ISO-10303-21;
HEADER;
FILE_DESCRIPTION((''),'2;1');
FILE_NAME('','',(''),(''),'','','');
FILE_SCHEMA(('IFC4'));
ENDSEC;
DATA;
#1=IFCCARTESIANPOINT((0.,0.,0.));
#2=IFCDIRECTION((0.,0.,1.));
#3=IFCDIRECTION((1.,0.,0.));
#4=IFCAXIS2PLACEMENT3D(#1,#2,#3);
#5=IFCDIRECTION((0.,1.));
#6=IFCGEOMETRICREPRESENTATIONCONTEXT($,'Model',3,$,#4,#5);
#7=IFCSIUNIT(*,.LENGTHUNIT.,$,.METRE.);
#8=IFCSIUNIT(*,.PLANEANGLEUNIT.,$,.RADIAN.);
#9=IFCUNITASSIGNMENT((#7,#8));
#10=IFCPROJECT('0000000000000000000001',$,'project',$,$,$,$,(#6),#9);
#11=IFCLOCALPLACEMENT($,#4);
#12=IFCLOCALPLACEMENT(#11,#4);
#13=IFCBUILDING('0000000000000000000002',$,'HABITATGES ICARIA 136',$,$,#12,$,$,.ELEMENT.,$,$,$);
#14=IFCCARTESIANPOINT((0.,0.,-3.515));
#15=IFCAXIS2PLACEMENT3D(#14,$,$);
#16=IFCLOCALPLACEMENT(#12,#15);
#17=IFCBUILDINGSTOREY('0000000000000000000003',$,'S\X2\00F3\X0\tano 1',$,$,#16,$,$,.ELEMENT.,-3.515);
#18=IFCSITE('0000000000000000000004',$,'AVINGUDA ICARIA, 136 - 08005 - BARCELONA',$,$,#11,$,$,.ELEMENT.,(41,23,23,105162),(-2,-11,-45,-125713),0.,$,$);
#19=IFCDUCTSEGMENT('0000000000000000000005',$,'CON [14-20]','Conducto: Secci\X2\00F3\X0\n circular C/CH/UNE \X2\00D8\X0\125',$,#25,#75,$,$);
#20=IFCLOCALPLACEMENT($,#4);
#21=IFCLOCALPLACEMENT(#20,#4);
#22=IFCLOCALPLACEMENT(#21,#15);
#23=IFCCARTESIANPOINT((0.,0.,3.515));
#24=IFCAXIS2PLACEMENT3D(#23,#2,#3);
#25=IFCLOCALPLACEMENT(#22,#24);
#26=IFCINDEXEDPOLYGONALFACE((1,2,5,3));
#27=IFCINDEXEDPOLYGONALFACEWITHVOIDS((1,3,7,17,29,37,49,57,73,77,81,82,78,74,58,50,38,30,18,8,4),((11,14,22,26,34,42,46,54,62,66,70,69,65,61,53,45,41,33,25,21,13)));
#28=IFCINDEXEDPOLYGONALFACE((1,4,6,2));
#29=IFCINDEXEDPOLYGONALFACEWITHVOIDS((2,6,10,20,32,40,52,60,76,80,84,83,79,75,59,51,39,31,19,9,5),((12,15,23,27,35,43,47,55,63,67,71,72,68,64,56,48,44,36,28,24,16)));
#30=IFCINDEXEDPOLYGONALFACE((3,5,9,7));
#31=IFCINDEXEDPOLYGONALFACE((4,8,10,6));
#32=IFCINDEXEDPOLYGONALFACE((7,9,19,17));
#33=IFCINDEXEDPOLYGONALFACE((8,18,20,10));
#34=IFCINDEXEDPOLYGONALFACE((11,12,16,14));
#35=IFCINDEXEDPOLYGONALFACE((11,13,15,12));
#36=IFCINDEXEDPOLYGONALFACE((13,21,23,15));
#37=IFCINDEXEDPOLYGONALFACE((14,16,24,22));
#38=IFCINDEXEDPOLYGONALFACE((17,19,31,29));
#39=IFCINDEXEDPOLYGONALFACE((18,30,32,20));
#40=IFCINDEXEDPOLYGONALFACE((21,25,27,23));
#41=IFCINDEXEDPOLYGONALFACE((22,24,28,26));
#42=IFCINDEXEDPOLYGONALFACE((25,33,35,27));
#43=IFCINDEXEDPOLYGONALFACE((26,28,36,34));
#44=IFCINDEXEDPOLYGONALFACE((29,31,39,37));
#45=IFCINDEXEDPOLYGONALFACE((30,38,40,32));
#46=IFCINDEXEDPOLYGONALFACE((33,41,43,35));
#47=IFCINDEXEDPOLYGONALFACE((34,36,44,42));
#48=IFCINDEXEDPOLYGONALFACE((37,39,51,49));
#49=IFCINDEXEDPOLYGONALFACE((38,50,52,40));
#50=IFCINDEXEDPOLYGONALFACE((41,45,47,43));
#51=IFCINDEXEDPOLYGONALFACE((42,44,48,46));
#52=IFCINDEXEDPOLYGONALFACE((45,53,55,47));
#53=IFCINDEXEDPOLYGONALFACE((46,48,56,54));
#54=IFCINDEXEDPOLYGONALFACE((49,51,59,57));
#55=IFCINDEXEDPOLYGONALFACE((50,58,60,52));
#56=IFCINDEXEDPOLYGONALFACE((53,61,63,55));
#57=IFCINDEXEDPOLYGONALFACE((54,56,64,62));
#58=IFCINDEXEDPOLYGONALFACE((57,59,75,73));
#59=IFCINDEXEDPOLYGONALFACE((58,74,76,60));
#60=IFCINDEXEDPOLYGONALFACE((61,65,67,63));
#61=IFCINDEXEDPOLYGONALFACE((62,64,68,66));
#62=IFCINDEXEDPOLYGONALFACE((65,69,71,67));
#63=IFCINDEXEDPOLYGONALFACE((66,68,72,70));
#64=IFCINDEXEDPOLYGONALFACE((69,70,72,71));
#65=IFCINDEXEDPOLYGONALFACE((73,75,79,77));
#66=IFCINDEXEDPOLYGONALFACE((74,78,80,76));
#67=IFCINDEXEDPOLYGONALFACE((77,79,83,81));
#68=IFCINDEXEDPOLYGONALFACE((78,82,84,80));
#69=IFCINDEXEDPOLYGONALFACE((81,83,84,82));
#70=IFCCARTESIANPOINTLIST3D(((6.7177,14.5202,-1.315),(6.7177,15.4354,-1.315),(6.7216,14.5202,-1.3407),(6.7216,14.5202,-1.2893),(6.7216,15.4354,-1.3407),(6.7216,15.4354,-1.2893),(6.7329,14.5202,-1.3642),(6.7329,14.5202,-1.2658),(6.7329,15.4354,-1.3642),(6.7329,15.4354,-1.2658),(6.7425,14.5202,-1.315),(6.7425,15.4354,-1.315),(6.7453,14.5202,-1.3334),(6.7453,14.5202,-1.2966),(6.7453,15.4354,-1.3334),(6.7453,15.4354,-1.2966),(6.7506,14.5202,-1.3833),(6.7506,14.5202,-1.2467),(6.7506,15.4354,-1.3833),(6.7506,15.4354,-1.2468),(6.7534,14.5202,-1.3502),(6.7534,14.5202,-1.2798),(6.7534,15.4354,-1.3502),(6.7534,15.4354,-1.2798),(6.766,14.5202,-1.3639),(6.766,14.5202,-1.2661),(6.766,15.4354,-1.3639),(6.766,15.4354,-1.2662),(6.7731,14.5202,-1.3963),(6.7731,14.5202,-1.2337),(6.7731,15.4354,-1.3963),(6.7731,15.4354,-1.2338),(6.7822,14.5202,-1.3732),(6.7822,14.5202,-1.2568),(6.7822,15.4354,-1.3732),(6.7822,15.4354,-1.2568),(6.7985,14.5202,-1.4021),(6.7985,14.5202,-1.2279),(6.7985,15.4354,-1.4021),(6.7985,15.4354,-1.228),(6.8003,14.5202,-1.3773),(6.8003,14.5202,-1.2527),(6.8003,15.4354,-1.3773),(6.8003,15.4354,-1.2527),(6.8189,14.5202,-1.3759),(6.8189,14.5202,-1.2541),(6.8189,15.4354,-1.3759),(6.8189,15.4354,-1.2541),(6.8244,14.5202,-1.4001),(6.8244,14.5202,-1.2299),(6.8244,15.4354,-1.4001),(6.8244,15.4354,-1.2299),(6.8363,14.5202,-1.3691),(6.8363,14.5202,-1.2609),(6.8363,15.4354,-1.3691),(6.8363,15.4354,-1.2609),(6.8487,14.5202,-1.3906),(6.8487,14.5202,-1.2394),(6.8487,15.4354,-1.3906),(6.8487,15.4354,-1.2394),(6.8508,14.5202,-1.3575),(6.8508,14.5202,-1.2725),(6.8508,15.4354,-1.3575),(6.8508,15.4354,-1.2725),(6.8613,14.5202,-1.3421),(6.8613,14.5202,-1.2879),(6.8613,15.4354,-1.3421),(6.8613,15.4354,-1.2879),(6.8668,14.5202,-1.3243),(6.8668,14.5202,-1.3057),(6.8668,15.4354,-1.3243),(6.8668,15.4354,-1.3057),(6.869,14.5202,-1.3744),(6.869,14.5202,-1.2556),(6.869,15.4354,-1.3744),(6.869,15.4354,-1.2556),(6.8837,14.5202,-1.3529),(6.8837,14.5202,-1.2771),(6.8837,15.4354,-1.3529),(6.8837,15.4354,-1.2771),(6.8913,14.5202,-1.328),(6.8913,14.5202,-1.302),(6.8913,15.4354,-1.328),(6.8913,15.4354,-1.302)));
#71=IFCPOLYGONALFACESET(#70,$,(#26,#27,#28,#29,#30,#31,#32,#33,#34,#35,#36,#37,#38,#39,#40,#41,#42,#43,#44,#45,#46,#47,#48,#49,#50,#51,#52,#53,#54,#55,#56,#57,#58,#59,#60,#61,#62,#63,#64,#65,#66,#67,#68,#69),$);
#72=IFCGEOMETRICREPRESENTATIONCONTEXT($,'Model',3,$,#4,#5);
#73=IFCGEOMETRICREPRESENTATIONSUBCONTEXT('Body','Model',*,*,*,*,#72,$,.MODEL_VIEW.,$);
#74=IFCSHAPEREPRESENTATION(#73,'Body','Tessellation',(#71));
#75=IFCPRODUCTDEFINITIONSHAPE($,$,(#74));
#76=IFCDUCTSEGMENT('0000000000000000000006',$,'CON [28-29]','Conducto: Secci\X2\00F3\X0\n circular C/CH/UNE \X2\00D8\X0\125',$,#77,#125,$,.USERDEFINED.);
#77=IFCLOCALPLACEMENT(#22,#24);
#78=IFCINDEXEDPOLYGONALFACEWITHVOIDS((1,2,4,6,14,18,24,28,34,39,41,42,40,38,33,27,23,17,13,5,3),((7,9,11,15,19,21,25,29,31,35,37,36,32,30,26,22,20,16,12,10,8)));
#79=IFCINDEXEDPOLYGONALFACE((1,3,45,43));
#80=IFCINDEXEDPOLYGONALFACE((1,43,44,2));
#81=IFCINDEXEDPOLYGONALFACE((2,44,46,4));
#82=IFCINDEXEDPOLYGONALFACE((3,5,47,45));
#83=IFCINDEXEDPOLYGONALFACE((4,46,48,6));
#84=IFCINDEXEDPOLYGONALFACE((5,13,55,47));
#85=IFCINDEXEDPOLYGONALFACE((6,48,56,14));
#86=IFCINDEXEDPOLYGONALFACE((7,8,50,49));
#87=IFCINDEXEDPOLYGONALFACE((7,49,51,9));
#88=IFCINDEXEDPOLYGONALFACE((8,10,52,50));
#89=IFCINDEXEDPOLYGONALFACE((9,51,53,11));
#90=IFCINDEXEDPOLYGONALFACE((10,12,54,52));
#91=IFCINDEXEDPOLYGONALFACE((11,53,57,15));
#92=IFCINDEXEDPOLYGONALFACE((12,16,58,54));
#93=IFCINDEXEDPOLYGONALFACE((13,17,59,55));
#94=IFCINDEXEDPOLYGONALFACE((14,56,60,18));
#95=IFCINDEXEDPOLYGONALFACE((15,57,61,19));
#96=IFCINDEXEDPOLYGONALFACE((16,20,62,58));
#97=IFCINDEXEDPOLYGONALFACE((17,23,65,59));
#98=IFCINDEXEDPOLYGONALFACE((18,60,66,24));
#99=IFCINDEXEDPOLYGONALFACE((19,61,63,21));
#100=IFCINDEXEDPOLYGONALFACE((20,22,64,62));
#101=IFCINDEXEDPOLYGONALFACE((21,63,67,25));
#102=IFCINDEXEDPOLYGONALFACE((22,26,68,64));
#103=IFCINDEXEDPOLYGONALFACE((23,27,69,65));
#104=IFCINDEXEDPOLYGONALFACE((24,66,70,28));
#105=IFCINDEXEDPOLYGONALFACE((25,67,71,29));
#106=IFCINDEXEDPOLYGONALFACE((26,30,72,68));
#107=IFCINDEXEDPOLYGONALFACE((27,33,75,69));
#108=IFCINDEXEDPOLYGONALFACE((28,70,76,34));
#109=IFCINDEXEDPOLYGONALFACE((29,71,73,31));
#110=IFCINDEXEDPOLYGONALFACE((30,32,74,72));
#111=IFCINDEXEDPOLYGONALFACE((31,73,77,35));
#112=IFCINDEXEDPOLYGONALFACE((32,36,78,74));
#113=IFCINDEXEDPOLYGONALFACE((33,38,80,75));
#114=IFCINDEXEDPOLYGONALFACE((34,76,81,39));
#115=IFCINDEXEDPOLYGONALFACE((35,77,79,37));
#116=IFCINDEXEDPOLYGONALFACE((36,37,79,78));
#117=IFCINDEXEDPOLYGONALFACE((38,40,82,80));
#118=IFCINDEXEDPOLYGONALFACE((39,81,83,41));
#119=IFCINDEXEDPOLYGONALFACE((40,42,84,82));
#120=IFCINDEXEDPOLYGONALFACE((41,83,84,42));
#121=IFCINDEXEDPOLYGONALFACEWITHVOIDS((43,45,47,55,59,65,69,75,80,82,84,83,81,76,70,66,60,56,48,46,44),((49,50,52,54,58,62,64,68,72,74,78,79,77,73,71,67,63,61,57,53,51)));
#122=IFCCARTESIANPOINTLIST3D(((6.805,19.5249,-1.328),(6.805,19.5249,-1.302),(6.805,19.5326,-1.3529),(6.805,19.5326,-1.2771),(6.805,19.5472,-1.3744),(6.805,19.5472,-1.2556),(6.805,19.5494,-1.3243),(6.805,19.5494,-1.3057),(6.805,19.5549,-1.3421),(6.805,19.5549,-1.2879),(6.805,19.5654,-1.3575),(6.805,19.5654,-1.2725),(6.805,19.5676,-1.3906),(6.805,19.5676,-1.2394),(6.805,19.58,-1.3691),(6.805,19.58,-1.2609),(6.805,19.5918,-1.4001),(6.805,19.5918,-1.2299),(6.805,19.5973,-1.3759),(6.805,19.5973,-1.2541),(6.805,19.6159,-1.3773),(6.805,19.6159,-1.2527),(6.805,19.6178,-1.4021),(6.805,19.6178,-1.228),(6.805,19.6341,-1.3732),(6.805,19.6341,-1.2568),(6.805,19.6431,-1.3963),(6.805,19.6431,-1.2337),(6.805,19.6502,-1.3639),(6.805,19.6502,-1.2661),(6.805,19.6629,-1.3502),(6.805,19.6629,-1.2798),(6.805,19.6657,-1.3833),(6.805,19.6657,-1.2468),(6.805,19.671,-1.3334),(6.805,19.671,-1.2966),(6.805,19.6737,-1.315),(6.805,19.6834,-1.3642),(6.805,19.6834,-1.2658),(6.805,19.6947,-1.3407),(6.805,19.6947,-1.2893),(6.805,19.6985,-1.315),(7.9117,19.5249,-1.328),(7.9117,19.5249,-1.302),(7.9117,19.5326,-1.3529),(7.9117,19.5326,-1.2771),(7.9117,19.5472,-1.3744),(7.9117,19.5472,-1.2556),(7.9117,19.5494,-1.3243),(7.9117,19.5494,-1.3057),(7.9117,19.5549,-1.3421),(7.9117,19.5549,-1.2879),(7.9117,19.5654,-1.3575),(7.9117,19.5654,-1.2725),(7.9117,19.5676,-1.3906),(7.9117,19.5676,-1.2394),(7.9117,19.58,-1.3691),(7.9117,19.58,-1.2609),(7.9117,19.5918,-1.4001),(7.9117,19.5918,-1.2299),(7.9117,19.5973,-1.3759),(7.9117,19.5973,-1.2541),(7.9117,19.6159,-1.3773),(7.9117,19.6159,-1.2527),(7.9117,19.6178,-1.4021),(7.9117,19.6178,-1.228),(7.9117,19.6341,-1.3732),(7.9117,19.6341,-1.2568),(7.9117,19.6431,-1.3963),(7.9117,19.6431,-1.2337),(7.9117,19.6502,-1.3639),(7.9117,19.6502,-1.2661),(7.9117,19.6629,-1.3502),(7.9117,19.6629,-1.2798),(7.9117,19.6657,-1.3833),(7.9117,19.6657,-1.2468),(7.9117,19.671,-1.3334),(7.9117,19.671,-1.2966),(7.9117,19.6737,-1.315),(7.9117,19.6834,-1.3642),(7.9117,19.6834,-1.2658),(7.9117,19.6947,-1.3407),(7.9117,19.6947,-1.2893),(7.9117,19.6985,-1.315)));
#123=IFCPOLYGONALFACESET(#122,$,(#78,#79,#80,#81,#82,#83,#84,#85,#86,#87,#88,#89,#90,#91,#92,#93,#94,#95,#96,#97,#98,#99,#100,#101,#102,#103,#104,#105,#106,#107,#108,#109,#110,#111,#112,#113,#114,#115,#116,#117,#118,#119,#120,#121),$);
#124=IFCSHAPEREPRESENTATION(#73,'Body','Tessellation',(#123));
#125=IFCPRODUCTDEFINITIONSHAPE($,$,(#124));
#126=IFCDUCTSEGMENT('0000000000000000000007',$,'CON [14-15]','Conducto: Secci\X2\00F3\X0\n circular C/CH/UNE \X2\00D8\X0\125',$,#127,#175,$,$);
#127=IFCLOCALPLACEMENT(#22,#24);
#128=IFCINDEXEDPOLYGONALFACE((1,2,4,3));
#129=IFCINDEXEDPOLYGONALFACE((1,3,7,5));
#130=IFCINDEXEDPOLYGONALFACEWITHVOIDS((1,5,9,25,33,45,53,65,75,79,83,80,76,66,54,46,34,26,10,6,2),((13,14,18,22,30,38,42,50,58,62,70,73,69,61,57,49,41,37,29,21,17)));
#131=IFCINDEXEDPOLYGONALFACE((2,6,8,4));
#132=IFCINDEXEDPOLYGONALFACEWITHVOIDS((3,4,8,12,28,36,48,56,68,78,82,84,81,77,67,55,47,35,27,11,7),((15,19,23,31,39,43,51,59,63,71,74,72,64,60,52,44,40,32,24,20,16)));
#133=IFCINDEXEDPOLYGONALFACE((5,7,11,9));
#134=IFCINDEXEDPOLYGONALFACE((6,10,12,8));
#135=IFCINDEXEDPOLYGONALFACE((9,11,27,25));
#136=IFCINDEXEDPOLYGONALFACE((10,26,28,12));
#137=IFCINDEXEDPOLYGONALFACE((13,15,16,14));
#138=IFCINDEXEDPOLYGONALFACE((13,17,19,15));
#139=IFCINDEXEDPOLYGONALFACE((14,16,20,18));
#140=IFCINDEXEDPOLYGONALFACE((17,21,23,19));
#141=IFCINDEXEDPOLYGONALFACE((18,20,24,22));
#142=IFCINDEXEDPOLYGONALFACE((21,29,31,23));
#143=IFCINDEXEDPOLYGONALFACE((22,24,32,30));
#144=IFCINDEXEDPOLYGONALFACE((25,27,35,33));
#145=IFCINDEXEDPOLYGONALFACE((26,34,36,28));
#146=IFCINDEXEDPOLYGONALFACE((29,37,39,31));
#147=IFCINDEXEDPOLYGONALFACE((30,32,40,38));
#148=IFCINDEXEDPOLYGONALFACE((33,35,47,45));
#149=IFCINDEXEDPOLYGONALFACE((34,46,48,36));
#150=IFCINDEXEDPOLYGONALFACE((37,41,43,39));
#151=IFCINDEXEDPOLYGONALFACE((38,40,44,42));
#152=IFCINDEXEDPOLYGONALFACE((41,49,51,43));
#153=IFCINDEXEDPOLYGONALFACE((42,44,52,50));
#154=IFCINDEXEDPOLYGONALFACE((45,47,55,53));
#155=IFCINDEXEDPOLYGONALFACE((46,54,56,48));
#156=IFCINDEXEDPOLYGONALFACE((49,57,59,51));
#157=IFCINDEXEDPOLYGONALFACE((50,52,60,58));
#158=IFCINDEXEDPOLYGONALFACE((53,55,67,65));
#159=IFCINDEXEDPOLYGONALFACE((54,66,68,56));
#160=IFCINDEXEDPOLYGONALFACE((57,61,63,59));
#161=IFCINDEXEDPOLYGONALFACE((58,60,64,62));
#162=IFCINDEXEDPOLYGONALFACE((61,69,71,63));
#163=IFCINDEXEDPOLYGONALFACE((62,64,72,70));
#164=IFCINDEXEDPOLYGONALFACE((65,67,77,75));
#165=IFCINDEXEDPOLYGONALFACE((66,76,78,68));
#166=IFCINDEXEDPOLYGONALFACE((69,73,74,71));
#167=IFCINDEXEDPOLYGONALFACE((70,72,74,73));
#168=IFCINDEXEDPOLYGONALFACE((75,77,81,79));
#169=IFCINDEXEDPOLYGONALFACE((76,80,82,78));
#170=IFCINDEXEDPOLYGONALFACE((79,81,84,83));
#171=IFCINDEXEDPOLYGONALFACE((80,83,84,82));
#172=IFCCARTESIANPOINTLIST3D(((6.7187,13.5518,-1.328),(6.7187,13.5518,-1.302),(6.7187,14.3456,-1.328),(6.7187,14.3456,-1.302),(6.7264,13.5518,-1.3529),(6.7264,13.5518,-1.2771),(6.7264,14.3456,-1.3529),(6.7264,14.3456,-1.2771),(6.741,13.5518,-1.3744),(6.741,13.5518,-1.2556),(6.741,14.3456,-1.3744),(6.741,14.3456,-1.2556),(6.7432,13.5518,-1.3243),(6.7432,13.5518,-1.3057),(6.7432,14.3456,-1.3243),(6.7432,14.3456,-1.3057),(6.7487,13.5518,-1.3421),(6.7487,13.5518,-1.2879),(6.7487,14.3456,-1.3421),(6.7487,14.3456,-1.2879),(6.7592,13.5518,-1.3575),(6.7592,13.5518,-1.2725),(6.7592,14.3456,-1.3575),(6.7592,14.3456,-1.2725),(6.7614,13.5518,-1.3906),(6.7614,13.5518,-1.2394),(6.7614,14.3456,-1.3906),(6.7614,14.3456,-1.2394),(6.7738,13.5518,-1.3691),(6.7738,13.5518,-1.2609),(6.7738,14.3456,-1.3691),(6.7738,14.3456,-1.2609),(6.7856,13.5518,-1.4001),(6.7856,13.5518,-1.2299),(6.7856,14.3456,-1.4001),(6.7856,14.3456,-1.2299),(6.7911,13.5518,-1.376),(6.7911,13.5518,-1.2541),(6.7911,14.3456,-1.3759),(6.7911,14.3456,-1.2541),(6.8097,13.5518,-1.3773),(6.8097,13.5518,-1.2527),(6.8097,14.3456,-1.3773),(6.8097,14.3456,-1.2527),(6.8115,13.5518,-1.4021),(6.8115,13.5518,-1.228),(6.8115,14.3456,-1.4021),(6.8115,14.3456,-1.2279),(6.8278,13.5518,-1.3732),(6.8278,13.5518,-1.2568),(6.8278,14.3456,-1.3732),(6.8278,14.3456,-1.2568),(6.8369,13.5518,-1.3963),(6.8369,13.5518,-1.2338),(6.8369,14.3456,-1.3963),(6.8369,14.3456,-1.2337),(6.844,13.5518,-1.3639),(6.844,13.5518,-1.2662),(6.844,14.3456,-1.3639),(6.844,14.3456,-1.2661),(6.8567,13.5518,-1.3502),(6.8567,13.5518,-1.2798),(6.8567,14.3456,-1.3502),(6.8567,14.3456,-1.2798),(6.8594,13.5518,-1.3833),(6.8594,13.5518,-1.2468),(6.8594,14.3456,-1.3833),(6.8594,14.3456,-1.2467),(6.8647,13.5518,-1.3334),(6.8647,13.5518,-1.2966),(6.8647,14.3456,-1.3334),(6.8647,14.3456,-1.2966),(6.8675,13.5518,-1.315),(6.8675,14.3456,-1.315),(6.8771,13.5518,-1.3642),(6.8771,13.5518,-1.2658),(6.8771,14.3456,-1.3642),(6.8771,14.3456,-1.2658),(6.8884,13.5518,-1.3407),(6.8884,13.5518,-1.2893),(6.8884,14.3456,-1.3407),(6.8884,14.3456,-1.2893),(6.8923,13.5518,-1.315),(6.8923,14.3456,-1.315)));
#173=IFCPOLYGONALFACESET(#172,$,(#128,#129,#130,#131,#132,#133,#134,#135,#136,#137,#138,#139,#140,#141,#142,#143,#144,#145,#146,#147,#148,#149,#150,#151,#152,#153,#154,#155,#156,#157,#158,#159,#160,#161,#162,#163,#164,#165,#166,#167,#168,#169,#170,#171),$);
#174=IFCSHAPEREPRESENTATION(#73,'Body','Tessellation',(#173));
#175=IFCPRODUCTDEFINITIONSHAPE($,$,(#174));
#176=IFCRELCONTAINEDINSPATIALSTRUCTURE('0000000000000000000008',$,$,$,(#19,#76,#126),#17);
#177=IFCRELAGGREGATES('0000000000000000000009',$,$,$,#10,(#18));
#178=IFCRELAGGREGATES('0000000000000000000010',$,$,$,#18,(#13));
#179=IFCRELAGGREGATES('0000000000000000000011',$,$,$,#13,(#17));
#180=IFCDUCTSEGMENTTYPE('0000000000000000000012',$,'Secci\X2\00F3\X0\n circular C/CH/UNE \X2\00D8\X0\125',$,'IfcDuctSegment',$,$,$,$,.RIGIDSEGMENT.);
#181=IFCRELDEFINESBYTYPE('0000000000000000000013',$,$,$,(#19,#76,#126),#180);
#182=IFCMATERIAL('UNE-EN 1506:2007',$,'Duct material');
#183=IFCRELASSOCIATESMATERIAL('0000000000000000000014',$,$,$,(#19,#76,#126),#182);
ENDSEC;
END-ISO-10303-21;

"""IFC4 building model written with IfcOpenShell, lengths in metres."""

from ifc_helpers import new_model, si_unit, direction, frame, origin_with_axes, origin_2d_with_axis, place, context, subcontext, project, spatial, hollow_circle, extrude, material, type_object, element, save


model = new_model("IFC4")

# Units and contexts
model_context_1 = context("Model", 3, world=origin_with_axes(), true_north=direction((0.0, 1.0)))
model_context_2 = context("Model", 3, world=origin_with_axes(), true_north=direction((0.0, 1.0)))
body_context_1 = subcontext(model_context_2, "Body", "Model", "MODEL_VIEW")
ifc_project = project(units=[si_unit("LENGTHUNIT", "METRE"), si_unit("PLANEANGLEUNIT", "RADIAN")], contexts=[model_context_1])

# Site, building, storey
site_placement = place(None, origin_with_axes())
site = spatial("IfcSite", under=ifc_project, at=site_placement, Name="AVINGUDA ICARIA, 136 - 08005 - BARCELONA", CompositionType="ELEMENT", RefLatitude=(41, 23, 23, 105162), RefLongitude=(-2, -11, -45, -125713), RefElevation=0.0)
building_placement = place(site_placement, origin_with_axes())
building = spatial("IfcBuilding", under=site, at=building_placement, Name="HABITATGES ICARIA 136", CompositionType="ELEMENT")
storey_placement = place(building_placement, frame((0.0, 0.0, -3.515)))
storey = spatial("IfcBuildingStorey", under=building, at=storey_placement, Name="Sótano 1", CompositionType="ELEMENT", Elevation=-3.515)

# Duct segments
ifc_material_1 = material(Name="UNE-EN 1506:2007", Category="Duct material")
duct_segment_type = type_object("IfcDuctSegmentType", Name="Sección circular C/CH/UNE Ø125", ApplicableOccurrence="IfcDuctSegment", PredefinedType="RIGIDSEGMENT")
placement_1 = place(None, origin_with_axes())
placement_2 = place(placement_1, origin_with_axes())
placement_3 = place(placement_2, frame((0.0, 0.0, -3.515)))
duct_segment_1_placement = place(placement_3, frame((0.0, 0.0, 3.515), z_axis=(0.0, 0.0, 1.0), x_axis=(1.0, 0.0, 0.0)))
element("IfcDuctSegment", 1, at=duct_segment_1_placement, inside=storey, type_object=duct_segment_type, material=ifc_material_1, Name="CON [14-20]", Description="Conducto: Sección circular C/CH/UNE Ø125", context=body_context_1, shape_type="SweptSolid", body=[
    extrude(hollow_circle(Radius=0.0873, WallThickness=0.0248, at=origin_2d_with_axis()), frame((6.805, 14.5202, -1.315), z_axis=(0.0, 1.0, -0.000017), x_axis=(-1.0, 0.0, 0.0)), (0.0, 0.0, 1.0), 0.9152),
])
duct_segment_2_placement = place(placement_3, frame((0.0, 0.0, 3.515), z_axis=(0.0, 0.0, 1.0), x_axis=(1.0, 0.0, 0.0)))
element("IfcDuctSegment", 2, at=duct_segment_2_placement, inside=storey, type_object=duct_segment_type, material=ifc_material_1, Name="CON [28-29]", Description="Conducto: Sección circular C/CH/UNE Ø125", PredefinedType="USERDEFINED", context=body_context_1, shape_type="SweptSolid", body=[
    extrude(hollow_circle(Radius=0.0873, WallThickness=0.0248, at=origin_2d_with_axis()), frame((6.805, 19.6112, -1.315), z_axis=(1.0, 0.0, 0.0), x_axis=(0.0, 1.0, 0.0)), (0.0, 0.0, 1.0), 1.1067),
])
duct_segment_3_placement = place(placement_3, frame((0.0, 0.0, 3.515), z_axis=(0.0, 0.0, 1.0), x_axis=(1.0, 0.0, 0.0)))
element("IfcDuctSegment", 3, at=duct_segment_3_placement, inside=storey, type_object=duct_segment_type, material=ifc_material_1, Name="CON [14-15]", Description="Conducto: Sección circular C/CH/UNE Ø125", context=body_context_1, shape_type="SweptSolid", body=[
    extrude(hollow_circle(Radius=0.0873, WallThickness=0.0248, at=origin_2d_with_axis()), frame((6.805, 14.3456, -1.315), z_axis=(0.0, -1.0, -0.00002), x_axis=(1.0, 0.0, 0.0)), (0.0, 0.0, 1.0), 0.7938),
])

save(model, "model.ifc")
